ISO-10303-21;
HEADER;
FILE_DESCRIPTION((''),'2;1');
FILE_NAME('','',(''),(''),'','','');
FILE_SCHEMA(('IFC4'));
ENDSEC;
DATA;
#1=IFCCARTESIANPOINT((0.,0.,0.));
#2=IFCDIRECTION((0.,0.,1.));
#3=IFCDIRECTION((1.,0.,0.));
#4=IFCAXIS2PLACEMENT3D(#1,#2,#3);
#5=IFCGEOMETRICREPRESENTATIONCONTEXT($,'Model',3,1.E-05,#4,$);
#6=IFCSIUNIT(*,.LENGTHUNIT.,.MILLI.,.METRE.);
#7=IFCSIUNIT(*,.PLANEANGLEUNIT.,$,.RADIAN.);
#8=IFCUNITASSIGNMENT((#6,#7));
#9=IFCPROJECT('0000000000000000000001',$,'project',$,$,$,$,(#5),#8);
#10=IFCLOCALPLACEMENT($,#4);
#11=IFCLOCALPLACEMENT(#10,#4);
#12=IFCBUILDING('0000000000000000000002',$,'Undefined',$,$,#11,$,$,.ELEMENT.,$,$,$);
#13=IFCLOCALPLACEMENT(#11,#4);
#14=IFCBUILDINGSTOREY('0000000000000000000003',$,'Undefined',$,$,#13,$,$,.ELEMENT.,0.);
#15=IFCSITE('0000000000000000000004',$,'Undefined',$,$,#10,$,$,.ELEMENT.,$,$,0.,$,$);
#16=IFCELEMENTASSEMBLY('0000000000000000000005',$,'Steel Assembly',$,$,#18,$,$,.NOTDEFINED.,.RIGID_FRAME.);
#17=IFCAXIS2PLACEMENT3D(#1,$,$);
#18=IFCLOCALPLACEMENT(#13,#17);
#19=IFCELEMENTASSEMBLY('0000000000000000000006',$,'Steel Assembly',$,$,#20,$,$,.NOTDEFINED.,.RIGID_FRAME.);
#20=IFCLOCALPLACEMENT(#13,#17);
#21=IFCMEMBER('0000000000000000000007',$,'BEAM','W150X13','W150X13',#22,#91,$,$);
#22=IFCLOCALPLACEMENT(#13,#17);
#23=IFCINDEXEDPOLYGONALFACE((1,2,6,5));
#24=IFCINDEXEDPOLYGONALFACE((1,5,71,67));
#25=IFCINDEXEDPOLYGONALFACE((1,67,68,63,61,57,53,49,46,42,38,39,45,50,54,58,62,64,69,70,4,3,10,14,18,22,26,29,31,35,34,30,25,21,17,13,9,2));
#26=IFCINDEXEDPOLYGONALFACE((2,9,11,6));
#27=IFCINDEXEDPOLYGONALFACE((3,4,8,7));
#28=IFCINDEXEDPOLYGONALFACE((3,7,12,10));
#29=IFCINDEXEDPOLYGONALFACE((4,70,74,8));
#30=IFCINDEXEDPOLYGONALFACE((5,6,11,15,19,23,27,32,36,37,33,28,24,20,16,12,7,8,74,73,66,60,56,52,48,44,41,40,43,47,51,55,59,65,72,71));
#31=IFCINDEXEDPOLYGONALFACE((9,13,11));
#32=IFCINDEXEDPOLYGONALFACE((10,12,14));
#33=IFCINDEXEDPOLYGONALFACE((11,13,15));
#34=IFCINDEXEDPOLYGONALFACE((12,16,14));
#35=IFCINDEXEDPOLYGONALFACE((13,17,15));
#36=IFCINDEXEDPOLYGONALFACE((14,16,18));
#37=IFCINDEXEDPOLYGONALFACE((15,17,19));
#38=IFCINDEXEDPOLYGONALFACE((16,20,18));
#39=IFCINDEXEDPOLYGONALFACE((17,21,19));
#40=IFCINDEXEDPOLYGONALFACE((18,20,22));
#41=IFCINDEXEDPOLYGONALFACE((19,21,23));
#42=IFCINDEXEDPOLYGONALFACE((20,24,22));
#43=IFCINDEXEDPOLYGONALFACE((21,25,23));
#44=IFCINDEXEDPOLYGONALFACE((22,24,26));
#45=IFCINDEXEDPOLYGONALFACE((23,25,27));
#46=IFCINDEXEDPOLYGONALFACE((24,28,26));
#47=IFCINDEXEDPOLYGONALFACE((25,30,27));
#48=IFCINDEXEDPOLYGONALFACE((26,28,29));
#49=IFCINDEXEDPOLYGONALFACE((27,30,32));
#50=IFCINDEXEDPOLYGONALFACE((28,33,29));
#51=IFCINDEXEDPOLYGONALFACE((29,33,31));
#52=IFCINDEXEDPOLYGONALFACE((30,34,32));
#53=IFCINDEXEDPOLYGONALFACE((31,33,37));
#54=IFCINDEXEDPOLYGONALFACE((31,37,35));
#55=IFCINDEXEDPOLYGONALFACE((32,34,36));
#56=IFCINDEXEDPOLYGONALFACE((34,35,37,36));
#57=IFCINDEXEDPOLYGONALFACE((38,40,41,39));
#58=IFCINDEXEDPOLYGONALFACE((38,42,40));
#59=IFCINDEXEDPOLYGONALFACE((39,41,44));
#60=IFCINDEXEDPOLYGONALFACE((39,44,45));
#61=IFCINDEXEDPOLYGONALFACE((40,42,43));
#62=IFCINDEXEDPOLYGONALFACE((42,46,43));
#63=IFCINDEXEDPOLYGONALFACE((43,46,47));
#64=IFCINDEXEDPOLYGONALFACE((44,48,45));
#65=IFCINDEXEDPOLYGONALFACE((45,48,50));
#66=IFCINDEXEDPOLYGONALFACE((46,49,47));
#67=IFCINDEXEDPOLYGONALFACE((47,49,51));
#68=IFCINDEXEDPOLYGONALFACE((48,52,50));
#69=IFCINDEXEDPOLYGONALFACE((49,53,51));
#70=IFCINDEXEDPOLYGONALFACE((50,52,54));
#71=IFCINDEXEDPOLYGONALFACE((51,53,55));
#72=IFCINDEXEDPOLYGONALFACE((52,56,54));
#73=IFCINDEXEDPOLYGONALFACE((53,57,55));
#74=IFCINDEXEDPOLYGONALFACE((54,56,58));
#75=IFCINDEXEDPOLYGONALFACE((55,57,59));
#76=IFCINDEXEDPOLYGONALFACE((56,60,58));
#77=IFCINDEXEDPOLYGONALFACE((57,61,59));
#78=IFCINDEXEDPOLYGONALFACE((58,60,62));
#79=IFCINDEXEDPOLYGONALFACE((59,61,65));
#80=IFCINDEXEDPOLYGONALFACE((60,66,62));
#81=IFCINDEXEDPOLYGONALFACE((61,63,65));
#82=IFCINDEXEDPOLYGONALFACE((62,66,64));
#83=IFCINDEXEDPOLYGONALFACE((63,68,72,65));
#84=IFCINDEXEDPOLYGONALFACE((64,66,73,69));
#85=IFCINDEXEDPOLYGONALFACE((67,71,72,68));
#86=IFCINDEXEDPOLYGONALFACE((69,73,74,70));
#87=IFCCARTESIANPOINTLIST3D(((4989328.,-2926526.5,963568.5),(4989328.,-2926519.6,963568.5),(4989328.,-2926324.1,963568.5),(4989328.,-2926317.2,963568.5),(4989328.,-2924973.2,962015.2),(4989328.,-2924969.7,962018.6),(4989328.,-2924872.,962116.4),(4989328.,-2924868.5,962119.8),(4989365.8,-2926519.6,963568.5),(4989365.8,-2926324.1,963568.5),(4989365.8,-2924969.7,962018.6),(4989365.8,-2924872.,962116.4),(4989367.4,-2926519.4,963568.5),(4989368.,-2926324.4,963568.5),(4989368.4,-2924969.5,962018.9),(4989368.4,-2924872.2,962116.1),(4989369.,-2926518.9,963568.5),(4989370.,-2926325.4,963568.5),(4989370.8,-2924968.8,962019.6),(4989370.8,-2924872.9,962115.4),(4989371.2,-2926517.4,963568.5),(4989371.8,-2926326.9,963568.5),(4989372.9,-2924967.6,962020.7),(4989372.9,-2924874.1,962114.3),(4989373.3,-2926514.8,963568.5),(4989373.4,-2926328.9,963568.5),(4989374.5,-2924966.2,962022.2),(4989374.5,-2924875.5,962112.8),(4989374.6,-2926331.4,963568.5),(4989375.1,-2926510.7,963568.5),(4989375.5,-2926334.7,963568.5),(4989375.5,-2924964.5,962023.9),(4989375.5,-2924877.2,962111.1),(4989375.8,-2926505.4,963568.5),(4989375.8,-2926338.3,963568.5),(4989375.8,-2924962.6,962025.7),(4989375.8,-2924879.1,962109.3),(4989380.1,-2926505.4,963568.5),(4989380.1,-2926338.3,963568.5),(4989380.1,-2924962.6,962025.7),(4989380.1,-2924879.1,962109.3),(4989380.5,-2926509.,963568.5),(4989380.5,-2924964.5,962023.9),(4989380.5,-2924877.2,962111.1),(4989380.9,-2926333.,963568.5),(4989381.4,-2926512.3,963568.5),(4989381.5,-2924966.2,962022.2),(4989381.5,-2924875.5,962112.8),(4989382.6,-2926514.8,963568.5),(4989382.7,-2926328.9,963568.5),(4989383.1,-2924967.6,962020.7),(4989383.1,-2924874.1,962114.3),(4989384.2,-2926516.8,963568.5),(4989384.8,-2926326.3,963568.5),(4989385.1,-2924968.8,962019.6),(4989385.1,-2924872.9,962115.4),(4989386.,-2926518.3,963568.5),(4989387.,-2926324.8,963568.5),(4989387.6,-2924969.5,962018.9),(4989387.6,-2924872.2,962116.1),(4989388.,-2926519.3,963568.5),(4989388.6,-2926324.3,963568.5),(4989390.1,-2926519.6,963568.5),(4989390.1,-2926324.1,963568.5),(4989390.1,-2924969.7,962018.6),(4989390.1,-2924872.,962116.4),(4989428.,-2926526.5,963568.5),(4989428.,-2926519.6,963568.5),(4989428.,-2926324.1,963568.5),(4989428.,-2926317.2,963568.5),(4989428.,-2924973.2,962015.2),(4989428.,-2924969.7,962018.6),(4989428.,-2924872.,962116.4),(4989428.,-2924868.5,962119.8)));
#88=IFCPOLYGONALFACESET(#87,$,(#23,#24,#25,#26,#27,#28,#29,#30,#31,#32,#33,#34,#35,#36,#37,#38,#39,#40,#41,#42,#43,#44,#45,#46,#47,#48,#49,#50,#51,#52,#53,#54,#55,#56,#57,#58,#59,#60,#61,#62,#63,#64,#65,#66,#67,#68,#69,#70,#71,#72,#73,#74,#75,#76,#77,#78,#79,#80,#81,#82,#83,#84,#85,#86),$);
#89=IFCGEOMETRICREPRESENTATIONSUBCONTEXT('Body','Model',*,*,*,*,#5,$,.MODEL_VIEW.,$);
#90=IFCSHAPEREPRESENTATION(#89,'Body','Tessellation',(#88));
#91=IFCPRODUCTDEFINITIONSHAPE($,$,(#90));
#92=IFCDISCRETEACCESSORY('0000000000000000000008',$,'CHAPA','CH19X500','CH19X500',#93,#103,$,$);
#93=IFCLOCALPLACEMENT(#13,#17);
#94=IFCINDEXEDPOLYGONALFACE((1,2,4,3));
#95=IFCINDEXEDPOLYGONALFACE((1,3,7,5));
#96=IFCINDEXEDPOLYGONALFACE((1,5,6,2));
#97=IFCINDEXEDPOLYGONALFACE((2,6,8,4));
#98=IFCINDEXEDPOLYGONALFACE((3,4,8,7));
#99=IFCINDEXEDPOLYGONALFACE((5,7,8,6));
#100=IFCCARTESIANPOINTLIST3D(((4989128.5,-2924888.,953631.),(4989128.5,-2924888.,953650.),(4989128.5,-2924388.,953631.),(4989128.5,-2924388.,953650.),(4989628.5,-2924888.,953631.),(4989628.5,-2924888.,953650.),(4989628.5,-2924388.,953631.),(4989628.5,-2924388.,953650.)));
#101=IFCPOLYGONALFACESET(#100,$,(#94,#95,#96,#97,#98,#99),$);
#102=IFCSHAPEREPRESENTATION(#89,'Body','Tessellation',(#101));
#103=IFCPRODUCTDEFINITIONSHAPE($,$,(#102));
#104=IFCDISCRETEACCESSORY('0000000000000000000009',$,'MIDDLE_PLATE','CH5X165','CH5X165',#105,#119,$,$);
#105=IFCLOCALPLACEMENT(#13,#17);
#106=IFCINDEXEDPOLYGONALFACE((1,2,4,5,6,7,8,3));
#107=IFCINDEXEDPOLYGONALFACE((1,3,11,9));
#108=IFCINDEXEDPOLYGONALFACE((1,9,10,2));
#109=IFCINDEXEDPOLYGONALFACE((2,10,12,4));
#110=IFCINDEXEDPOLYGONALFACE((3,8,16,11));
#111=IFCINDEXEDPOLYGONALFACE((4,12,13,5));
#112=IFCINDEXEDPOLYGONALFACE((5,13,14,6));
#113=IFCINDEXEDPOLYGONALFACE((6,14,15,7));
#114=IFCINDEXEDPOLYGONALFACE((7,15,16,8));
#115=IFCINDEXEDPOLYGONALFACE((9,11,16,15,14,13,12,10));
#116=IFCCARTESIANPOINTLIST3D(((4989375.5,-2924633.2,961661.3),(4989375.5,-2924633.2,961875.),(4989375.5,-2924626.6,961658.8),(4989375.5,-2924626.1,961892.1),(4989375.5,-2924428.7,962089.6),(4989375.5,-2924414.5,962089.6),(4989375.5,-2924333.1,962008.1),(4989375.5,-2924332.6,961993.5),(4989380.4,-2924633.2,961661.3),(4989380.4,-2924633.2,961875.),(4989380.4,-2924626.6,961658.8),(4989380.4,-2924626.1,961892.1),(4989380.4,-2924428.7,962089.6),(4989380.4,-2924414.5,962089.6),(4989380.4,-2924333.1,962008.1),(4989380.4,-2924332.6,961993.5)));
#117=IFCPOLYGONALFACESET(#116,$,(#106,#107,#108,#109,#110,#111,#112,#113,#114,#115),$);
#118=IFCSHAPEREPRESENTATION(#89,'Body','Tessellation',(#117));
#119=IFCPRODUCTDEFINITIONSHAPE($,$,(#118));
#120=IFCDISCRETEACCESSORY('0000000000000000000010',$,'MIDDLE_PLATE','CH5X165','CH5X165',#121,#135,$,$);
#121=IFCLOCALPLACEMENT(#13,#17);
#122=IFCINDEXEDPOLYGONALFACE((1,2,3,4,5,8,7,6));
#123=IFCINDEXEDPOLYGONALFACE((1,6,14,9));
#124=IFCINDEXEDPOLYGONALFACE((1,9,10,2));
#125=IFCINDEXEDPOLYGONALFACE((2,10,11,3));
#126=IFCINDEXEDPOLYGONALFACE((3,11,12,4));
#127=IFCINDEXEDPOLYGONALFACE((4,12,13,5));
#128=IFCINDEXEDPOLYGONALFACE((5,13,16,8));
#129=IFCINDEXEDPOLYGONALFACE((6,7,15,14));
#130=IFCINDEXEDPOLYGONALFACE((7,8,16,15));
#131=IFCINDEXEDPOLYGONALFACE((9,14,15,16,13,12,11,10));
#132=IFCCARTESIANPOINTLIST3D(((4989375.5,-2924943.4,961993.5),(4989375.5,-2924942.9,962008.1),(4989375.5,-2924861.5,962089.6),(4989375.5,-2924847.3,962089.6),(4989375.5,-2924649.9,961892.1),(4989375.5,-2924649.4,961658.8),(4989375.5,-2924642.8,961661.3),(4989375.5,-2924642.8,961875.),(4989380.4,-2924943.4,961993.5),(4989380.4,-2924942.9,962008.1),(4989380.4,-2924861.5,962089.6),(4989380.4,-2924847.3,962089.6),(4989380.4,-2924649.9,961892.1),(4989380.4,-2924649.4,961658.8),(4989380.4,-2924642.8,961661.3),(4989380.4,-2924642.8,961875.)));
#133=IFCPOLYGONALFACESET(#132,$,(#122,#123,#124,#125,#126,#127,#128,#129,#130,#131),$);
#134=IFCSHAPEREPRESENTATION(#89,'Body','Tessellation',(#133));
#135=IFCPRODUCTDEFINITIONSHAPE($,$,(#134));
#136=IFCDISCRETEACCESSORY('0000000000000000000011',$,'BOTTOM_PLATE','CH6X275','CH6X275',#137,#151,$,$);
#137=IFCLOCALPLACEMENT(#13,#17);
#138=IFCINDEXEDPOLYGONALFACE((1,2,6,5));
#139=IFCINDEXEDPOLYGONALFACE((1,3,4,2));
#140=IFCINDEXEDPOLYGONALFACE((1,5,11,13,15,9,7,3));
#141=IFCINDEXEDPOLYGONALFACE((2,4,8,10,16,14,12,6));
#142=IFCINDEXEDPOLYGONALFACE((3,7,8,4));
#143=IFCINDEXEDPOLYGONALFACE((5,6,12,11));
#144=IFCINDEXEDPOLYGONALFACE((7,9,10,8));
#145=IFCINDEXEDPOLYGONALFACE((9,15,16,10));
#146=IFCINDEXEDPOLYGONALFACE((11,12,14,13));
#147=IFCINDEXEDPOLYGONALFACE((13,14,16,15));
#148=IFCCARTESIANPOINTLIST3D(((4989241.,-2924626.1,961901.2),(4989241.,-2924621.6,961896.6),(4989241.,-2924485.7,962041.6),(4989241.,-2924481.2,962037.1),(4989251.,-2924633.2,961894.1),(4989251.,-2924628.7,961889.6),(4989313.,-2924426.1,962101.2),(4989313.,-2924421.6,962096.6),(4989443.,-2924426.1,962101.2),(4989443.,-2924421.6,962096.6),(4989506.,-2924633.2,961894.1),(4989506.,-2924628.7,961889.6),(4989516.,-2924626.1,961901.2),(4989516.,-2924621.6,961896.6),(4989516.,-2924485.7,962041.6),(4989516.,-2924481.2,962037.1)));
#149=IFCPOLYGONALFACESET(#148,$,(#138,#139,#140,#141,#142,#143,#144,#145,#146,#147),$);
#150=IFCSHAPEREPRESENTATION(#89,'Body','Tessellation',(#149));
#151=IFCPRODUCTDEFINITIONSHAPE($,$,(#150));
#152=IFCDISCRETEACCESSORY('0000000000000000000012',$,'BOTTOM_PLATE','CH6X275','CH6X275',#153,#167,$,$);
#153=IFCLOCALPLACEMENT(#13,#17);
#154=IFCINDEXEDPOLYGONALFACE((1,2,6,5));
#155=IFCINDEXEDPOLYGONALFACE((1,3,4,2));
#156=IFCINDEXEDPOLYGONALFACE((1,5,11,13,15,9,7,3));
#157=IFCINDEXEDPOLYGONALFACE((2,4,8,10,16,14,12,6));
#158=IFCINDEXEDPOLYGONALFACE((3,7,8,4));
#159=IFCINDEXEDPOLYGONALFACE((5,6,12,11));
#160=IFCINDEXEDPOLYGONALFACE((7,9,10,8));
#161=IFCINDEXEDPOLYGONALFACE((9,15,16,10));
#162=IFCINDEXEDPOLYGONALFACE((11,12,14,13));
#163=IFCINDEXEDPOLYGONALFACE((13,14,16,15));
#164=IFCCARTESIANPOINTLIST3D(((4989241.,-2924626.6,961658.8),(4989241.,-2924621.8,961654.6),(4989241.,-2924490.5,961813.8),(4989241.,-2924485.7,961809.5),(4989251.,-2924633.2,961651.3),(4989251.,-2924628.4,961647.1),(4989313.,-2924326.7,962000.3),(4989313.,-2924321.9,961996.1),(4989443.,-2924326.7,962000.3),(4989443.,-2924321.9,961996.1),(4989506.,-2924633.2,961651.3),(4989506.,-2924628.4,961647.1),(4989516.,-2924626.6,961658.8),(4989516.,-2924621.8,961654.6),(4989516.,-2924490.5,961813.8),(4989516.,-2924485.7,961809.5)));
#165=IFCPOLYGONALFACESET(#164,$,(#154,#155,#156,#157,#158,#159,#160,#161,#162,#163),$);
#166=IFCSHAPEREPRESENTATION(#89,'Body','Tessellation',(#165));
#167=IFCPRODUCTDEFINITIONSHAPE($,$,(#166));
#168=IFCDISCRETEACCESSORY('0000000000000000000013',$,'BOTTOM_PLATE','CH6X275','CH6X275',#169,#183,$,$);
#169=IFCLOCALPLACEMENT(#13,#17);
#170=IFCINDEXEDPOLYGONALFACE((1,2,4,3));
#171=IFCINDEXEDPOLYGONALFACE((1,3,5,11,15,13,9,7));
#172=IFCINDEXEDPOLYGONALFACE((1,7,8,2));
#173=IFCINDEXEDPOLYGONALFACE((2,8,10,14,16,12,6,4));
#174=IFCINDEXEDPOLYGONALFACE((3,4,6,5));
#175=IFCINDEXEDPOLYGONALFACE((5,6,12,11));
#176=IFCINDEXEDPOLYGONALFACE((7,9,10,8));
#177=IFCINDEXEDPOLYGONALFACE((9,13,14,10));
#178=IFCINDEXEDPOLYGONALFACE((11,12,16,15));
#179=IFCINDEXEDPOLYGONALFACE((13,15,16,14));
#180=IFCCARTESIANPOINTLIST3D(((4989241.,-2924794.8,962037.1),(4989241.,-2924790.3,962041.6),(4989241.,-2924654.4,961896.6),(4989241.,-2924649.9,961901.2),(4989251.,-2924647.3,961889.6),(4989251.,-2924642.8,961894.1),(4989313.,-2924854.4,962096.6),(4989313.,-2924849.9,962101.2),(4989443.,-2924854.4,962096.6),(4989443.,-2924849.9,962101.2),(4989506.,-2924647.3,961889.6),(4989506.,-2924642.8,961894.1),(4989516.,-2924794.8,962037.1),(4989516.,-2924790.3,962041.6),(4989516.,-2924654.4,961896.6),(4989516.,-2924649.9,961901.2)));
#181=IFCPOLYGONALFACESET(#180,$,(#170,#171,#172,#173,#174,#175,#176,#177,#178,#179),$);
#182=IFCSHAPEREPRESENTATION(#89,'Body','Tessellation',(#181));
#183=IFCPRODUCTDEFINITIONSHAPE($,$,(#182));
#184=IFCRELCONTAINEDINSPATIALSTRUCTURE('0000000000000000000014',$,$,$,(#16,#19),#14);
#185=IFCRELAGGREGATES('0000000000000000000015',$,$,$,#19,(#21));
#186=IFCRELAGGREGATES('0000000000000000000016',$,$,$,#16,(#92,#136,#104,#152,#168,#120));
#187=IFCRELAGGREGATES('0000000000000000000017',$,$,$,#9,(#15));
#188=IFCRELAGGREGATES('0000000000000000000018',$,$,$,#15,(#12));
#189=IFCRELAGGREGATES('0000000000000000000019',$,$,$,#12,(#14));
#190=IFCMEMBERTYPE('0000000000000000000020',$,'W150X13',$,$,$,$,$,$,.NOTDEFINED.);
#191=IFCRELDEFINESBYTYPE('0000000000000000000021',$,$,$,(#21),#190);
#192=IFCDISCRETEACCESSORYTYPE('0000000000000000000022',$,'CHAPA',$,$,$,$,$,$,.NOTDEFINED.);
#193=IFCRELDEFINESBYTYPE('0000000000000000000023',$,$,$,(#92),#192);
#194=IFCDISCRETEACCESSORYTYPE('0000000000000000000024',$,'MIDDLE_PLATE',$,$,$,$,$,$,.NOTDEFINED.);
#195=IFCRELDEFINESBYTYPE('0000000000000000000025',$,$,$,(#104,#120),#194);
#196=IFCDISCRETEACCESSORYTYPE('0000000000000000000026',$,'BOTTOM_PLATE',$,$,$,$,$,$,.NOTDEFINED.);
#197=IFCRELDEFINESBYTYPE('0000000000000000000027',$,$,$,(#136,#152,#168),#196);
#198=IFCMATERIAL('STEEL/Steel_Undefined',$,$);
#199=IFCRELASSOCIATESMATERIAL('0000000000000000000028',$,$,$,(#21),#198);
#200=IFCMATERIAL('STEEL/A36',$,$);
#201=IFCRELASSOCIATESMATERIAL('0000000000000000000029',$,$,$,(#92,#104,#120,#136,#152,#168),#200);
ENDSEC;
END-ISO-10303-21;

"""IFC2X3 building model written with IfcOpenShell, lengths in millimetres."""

from ifc_helpers import new_model, si_unit, frame, origin_with_axes, origin_2d_with_axis, place, context, subcontext, project, spatial, polyline, i_section, outline, extrude, clip, halfspace, material, type_object, element, aggregate, save


model = new_model("IFC2X3")

# Units and contexts
model_context = context("Model", 3, precision=1e-05, world=origin_with_axes())
body_context = subcontext(model_context, "Body", "Model", "MODEL_VIEW")
ifc_project = project(units=[si_unit("LENGTHUNIT", "METRE", prefix="MILLI"), si_unit("PLANEANGLEUNIT", "RADIAN")], contexts=[model_context])

# Site, building, storey
site_placement = place(None, origin_with_axes())
site = spatial("IfcSite", under=ifc_project, at=site_placement, Name="Undefined", CompositionType="ELEMENT", RefElevation=0.0)
building_placement = place(site_placement, origin_with_axes())
building = spatial("IfcBuilding", under=site, at=building_placement, Name="Undefined", CompositionType="ELEMENT")
storey_placement = place(building_placement, origin_with_axes())
storey = spatial("IfcBuildingStorey", under=building, at=storey_placement, Name="Undefined", CompositionType="ELEMENT", Elevation=0.0)

# Element assembly
assembly_1_placement = place(storey_placement, origin_with_axes())
assembly_1 = element("IfcElementAssembly", 1, at=assembly_1_placement, inside=storey, Name="Steel Assembly", AssemblyPlace="NOTDEFINED", PredefinedType="RIGID_FRAME")

# Element assembly, member
assembly_2_placement = place(storey_placement, origin_with_axes())
assembly_2 = element("IfcElementAssembly", 2, at=assembly_2_placement, inside=storey, Name="Steel Assembly", AssemblyPlace="NOTDEFINED", PredefinedType="RIGID_FRAME")
ifc_material_1 = material(Name="STEEL/Steel_Undefined")
member_type = type_object("IfcMemberType", Name="W150X13", PredefinedType="NOTDEFINED")
member_placement = place(assembly_2_placement, frame((4989378.0, -2924567.9, 961714.5), z_axis=(0.0, -0.707107, -0.707107), x_axis=(0.0, -0.707107, 0.707107)))
member = element("IfcMember", 3, at=member_placement, type_object=member_type, material=ifc_material_1, Name="BEAM", Description="W150X13", ObjectType="W150X13", context=body_context, shape_type="Clipping", body=[
    clip(clip(clip(extrude(i_section(OverallWidth=100.0, OverallDepth=148.0, WebThickness=4.3, FlangeThickness=4.9, FilletRadius=10.0, at=origin_2d_with_axis()), frame((2771.4, 0.0, 0.0), z_axis=(-1.0, 0.0, 0.0), x_axis=(0.0, -1.0, 0.0)), (0.0, 0.0, 1.0), 2771.4), halfspace(frame((2548.6, -50.0, -74.0), z_axis=(0.707107, 0.0, -0.707107), x_axis=(0.707107, 0.0, 0.707107)), False)), halfspace(frame((499.2, 50.0, -74.0), z_axis=(-1.0, 0.0, 0.0), x_axis=(0.0, 0.0, 1.0)), False)), halfspace(frame((2547.9, 0.0, -74.0), z_axis=(-0.707107, 0.0, 0.707107), x_axis=(0.0, 1.0, 0.0)), True)),
])

# Discrete accessories
ifc_material_2 = material(Name="STEEL/A36")
discrete_accessory_type_1 = type_object("IfcDiscreteAccessoryType", Name="CHAPA")
discrete_accessory_1_placement = place(assembly_1_placement, frame((4989628.5, -2924638.0, 953640.5), z_axis=(0.0, 0.0, 1.0), x_axis=(-1.0, 0.0, 0.0)))
discrete_accessory_1 = element("IfcDiscreteAccessory", 4, at=discrete_accessory_1_placement, type_object=discrete_accessory_type_1, material=ifc_material_2, Name="CHAPA", Description="CH19X500", ObjectType="CH19X500", context=body_context, shape_type="SweptSolid", body=[
    extrude(outline(polyline([(500.0, 250.0), (500.0, -250.0), (0.0, -250.0), (0.0, 250.0), (500.0, 250.0)])), frame((0.0, 0.0, -9.5), z_axis=(0.0, 0.0, 1.0), x_axis=(1.0, 0.0, 0.0)), (0.0, 0.0, 1.0), 19.0),
])
discrete_accessory_type_2 = type_object("IfcDiscreteAccessoryType", Name="MIDDLE_PLATE")
discrete_accessory_2_placement = place(assembly_1_placement, frame((4989378.0, -2924421.6, 962096.6), z_axis=(1.0, 0.0, 0.0), x_axis=(0.0, -0.707107, -0.707107)))
discrete_accessory_2 = element("IfcDiscreteAccessory", 5, at=discrete_accessory_2_placement, type_object=discrete_accessory_type_2, material=ifc_material_2, Name="MIDDLE_PLATE", Description="CH5X165", ObjectType="CH5X165", context=body_context, shape_type="SweptSolid", body=[
    extrude(outline(polyline([(0.0, 10.0), (10.0, 0.0), (289.2, 0.0), (306.3, 7.1), (457.4, 158.2), (454.5, 164.6), (10.0, 135.9), (0.0, 125.3), (0.0, 10.0)])), frame((0.0, 0.0, -2.5), z_axis=(0.0, 0.0, 1.0), x_axis=(1.0, 0.0, 0.0)), (0.0, 0.0, 1.0), 4.9),
])
discrete_accessory_3_placement = place(assembly_1_placement, frame((4989378.0, -2924854.4, 962096.6), z_axis=(-1.0, 0.0, 0.0), x_axis=(0.0, 0.707107, -0.707107)))
discrete_accessory_3 = element("IfcDiscreteAccessory", 6, at=discrete_accessory_3_placement, type_object=discrete_accessory_type_2, material=ifc_material_2, Name="MIDDLE_PLATE", Description="CH5X165", ObjectType="CH5X165", context=body_context, shape_type="SweptSolid", body=[
    extrude(outline(polyline([(0.0, 10.0), (10.0, 0.0), (289.2, 0.0), (306.3, 7.1), (457.4, 158.2), (454.5, 164.6), (10.0, 135.9), (0.0, 125.3), (0.0, 10.0)])), frame((0.0, 0.0, -2.5), z_axis=(0.0, 0.0, 1.0), x_axis=(1.0, 0.0, 0.0)), (0.0, 0.0, 1.0), 4.9),
])
discrete_accessory_type_3 = type_object("IfcDiscreteAccessoryType", Name="BOTTOM_PLATE")
discrete_accessory_4_placement = place(assembly_1_placement, frame((4989516.0, -2924483.4, 962039.3), z_axis=(0.0, 0.707107, -0.707107), x_axis=(0.0, -0.707107, -0.707107)))
discrete_accessory_4 = element("IfcDiscreteAccessory", 7, at=discrete_accessory_4_placement, type_object=discrete_accessory_type_3, material=ifc_material_2, Name="BOTTOM_PLATE", Description="CH6X275", ObjectType="CH6X275", context=body_context, shape_type="SweptSolid", body=[
    extrude(outline(polyline([(0.0, 0.0), (198.6, 0.0), (208.6, 10.0), (208.6, 265.0), (198.6, 275.0), (0.0, 275.0), (-84.2, 203.0), (-84.2, 73.0), (0.0, 0.0)])), frame((0.0, 0.0, -3.2), z_axis=(0.0, 0.0, 1.0), x_axis=(1.0, 0.0, 0.0)), (0.0, 0.0, 1.0), 6.4),
])
discrete_accessory_5_placement = place(assembly_1_placement, frame((4989516.0, -2924488.1, 961811.6), z_axis=(0.0, 0.75135, -0.659903), x_axis=(0.0, -0.659903, -0.75135)))
discrete_accessory_5 = element("IfcDiscreteAccessory", 8, at=discrete_accessory_5_placement, type_object=discrete_accessory_type_3, material=ifc_material_2, Name="BOTTOM_PLATE", Description="CH6X275", ObjectType="CH6X275", context=body_context, shape_type="SweptSolid", body=[
    extrude(outline(polyline([(0.0, 0.0), (206.2, 0.0), (216.2, 10.0), (216.2, 265.0), (206.2, 275.0), (0.0, 275.0), (-248.3, 203.0), (-248.3, 73.0), (0.0, 0.0)])), frame((0.0, 0.0, -3.2), z_axis=(0.0, 0.0, 1.0), x_axis=(1.0, 0.0, 0.0)), (0.0, 0.0, 1.0), 6.4),
])
discrete_accessory_6_placement = place(assembly_1_placement, frame((4989516.0, -2924792.6, 962039.3), z_axis=(0.0, 0.707107, 0.707107), x_axis=(0.0, 0.707107, -0.707107)))
discrete_accessory_6 = element("IfcDiscreteAccessory", 9, at=discrete_accessory_6_placement, type_object=discrete_accessory_type_3, material=ifc_material_2, Name="BOTTOM_PLATE", Description="CH6X275", ObjectType="CH6X275", context=body_context, shape_type="SweptSolid", body=[
    extrude(outline(polyline([(0.0, 0.0), (198.6, 0.0), (208.6, 10.0), (208.6, 265.0), (198.6, 275.0), (0.0, 275.0), (-84.2, 203.0), (-84.2, 73.0), (0.0, 0.0)])), frame((0.0, 0.0, -3.2), z_axis=(0.0, 0.0, 1.0), x_axis=(1.0, 0.0, 0.0)), (0.0, 0.0, 1.0), 6.4),
])

aggregate(assembly_2, [member])
aggregate(assembly_1, [discrete_accessory_1, discrete_accessory_4, discrete_accessory_2, discrete_accessory_5, discrete_accessory_6, discrete_accessory_3])

save(model, "model.ifc")
